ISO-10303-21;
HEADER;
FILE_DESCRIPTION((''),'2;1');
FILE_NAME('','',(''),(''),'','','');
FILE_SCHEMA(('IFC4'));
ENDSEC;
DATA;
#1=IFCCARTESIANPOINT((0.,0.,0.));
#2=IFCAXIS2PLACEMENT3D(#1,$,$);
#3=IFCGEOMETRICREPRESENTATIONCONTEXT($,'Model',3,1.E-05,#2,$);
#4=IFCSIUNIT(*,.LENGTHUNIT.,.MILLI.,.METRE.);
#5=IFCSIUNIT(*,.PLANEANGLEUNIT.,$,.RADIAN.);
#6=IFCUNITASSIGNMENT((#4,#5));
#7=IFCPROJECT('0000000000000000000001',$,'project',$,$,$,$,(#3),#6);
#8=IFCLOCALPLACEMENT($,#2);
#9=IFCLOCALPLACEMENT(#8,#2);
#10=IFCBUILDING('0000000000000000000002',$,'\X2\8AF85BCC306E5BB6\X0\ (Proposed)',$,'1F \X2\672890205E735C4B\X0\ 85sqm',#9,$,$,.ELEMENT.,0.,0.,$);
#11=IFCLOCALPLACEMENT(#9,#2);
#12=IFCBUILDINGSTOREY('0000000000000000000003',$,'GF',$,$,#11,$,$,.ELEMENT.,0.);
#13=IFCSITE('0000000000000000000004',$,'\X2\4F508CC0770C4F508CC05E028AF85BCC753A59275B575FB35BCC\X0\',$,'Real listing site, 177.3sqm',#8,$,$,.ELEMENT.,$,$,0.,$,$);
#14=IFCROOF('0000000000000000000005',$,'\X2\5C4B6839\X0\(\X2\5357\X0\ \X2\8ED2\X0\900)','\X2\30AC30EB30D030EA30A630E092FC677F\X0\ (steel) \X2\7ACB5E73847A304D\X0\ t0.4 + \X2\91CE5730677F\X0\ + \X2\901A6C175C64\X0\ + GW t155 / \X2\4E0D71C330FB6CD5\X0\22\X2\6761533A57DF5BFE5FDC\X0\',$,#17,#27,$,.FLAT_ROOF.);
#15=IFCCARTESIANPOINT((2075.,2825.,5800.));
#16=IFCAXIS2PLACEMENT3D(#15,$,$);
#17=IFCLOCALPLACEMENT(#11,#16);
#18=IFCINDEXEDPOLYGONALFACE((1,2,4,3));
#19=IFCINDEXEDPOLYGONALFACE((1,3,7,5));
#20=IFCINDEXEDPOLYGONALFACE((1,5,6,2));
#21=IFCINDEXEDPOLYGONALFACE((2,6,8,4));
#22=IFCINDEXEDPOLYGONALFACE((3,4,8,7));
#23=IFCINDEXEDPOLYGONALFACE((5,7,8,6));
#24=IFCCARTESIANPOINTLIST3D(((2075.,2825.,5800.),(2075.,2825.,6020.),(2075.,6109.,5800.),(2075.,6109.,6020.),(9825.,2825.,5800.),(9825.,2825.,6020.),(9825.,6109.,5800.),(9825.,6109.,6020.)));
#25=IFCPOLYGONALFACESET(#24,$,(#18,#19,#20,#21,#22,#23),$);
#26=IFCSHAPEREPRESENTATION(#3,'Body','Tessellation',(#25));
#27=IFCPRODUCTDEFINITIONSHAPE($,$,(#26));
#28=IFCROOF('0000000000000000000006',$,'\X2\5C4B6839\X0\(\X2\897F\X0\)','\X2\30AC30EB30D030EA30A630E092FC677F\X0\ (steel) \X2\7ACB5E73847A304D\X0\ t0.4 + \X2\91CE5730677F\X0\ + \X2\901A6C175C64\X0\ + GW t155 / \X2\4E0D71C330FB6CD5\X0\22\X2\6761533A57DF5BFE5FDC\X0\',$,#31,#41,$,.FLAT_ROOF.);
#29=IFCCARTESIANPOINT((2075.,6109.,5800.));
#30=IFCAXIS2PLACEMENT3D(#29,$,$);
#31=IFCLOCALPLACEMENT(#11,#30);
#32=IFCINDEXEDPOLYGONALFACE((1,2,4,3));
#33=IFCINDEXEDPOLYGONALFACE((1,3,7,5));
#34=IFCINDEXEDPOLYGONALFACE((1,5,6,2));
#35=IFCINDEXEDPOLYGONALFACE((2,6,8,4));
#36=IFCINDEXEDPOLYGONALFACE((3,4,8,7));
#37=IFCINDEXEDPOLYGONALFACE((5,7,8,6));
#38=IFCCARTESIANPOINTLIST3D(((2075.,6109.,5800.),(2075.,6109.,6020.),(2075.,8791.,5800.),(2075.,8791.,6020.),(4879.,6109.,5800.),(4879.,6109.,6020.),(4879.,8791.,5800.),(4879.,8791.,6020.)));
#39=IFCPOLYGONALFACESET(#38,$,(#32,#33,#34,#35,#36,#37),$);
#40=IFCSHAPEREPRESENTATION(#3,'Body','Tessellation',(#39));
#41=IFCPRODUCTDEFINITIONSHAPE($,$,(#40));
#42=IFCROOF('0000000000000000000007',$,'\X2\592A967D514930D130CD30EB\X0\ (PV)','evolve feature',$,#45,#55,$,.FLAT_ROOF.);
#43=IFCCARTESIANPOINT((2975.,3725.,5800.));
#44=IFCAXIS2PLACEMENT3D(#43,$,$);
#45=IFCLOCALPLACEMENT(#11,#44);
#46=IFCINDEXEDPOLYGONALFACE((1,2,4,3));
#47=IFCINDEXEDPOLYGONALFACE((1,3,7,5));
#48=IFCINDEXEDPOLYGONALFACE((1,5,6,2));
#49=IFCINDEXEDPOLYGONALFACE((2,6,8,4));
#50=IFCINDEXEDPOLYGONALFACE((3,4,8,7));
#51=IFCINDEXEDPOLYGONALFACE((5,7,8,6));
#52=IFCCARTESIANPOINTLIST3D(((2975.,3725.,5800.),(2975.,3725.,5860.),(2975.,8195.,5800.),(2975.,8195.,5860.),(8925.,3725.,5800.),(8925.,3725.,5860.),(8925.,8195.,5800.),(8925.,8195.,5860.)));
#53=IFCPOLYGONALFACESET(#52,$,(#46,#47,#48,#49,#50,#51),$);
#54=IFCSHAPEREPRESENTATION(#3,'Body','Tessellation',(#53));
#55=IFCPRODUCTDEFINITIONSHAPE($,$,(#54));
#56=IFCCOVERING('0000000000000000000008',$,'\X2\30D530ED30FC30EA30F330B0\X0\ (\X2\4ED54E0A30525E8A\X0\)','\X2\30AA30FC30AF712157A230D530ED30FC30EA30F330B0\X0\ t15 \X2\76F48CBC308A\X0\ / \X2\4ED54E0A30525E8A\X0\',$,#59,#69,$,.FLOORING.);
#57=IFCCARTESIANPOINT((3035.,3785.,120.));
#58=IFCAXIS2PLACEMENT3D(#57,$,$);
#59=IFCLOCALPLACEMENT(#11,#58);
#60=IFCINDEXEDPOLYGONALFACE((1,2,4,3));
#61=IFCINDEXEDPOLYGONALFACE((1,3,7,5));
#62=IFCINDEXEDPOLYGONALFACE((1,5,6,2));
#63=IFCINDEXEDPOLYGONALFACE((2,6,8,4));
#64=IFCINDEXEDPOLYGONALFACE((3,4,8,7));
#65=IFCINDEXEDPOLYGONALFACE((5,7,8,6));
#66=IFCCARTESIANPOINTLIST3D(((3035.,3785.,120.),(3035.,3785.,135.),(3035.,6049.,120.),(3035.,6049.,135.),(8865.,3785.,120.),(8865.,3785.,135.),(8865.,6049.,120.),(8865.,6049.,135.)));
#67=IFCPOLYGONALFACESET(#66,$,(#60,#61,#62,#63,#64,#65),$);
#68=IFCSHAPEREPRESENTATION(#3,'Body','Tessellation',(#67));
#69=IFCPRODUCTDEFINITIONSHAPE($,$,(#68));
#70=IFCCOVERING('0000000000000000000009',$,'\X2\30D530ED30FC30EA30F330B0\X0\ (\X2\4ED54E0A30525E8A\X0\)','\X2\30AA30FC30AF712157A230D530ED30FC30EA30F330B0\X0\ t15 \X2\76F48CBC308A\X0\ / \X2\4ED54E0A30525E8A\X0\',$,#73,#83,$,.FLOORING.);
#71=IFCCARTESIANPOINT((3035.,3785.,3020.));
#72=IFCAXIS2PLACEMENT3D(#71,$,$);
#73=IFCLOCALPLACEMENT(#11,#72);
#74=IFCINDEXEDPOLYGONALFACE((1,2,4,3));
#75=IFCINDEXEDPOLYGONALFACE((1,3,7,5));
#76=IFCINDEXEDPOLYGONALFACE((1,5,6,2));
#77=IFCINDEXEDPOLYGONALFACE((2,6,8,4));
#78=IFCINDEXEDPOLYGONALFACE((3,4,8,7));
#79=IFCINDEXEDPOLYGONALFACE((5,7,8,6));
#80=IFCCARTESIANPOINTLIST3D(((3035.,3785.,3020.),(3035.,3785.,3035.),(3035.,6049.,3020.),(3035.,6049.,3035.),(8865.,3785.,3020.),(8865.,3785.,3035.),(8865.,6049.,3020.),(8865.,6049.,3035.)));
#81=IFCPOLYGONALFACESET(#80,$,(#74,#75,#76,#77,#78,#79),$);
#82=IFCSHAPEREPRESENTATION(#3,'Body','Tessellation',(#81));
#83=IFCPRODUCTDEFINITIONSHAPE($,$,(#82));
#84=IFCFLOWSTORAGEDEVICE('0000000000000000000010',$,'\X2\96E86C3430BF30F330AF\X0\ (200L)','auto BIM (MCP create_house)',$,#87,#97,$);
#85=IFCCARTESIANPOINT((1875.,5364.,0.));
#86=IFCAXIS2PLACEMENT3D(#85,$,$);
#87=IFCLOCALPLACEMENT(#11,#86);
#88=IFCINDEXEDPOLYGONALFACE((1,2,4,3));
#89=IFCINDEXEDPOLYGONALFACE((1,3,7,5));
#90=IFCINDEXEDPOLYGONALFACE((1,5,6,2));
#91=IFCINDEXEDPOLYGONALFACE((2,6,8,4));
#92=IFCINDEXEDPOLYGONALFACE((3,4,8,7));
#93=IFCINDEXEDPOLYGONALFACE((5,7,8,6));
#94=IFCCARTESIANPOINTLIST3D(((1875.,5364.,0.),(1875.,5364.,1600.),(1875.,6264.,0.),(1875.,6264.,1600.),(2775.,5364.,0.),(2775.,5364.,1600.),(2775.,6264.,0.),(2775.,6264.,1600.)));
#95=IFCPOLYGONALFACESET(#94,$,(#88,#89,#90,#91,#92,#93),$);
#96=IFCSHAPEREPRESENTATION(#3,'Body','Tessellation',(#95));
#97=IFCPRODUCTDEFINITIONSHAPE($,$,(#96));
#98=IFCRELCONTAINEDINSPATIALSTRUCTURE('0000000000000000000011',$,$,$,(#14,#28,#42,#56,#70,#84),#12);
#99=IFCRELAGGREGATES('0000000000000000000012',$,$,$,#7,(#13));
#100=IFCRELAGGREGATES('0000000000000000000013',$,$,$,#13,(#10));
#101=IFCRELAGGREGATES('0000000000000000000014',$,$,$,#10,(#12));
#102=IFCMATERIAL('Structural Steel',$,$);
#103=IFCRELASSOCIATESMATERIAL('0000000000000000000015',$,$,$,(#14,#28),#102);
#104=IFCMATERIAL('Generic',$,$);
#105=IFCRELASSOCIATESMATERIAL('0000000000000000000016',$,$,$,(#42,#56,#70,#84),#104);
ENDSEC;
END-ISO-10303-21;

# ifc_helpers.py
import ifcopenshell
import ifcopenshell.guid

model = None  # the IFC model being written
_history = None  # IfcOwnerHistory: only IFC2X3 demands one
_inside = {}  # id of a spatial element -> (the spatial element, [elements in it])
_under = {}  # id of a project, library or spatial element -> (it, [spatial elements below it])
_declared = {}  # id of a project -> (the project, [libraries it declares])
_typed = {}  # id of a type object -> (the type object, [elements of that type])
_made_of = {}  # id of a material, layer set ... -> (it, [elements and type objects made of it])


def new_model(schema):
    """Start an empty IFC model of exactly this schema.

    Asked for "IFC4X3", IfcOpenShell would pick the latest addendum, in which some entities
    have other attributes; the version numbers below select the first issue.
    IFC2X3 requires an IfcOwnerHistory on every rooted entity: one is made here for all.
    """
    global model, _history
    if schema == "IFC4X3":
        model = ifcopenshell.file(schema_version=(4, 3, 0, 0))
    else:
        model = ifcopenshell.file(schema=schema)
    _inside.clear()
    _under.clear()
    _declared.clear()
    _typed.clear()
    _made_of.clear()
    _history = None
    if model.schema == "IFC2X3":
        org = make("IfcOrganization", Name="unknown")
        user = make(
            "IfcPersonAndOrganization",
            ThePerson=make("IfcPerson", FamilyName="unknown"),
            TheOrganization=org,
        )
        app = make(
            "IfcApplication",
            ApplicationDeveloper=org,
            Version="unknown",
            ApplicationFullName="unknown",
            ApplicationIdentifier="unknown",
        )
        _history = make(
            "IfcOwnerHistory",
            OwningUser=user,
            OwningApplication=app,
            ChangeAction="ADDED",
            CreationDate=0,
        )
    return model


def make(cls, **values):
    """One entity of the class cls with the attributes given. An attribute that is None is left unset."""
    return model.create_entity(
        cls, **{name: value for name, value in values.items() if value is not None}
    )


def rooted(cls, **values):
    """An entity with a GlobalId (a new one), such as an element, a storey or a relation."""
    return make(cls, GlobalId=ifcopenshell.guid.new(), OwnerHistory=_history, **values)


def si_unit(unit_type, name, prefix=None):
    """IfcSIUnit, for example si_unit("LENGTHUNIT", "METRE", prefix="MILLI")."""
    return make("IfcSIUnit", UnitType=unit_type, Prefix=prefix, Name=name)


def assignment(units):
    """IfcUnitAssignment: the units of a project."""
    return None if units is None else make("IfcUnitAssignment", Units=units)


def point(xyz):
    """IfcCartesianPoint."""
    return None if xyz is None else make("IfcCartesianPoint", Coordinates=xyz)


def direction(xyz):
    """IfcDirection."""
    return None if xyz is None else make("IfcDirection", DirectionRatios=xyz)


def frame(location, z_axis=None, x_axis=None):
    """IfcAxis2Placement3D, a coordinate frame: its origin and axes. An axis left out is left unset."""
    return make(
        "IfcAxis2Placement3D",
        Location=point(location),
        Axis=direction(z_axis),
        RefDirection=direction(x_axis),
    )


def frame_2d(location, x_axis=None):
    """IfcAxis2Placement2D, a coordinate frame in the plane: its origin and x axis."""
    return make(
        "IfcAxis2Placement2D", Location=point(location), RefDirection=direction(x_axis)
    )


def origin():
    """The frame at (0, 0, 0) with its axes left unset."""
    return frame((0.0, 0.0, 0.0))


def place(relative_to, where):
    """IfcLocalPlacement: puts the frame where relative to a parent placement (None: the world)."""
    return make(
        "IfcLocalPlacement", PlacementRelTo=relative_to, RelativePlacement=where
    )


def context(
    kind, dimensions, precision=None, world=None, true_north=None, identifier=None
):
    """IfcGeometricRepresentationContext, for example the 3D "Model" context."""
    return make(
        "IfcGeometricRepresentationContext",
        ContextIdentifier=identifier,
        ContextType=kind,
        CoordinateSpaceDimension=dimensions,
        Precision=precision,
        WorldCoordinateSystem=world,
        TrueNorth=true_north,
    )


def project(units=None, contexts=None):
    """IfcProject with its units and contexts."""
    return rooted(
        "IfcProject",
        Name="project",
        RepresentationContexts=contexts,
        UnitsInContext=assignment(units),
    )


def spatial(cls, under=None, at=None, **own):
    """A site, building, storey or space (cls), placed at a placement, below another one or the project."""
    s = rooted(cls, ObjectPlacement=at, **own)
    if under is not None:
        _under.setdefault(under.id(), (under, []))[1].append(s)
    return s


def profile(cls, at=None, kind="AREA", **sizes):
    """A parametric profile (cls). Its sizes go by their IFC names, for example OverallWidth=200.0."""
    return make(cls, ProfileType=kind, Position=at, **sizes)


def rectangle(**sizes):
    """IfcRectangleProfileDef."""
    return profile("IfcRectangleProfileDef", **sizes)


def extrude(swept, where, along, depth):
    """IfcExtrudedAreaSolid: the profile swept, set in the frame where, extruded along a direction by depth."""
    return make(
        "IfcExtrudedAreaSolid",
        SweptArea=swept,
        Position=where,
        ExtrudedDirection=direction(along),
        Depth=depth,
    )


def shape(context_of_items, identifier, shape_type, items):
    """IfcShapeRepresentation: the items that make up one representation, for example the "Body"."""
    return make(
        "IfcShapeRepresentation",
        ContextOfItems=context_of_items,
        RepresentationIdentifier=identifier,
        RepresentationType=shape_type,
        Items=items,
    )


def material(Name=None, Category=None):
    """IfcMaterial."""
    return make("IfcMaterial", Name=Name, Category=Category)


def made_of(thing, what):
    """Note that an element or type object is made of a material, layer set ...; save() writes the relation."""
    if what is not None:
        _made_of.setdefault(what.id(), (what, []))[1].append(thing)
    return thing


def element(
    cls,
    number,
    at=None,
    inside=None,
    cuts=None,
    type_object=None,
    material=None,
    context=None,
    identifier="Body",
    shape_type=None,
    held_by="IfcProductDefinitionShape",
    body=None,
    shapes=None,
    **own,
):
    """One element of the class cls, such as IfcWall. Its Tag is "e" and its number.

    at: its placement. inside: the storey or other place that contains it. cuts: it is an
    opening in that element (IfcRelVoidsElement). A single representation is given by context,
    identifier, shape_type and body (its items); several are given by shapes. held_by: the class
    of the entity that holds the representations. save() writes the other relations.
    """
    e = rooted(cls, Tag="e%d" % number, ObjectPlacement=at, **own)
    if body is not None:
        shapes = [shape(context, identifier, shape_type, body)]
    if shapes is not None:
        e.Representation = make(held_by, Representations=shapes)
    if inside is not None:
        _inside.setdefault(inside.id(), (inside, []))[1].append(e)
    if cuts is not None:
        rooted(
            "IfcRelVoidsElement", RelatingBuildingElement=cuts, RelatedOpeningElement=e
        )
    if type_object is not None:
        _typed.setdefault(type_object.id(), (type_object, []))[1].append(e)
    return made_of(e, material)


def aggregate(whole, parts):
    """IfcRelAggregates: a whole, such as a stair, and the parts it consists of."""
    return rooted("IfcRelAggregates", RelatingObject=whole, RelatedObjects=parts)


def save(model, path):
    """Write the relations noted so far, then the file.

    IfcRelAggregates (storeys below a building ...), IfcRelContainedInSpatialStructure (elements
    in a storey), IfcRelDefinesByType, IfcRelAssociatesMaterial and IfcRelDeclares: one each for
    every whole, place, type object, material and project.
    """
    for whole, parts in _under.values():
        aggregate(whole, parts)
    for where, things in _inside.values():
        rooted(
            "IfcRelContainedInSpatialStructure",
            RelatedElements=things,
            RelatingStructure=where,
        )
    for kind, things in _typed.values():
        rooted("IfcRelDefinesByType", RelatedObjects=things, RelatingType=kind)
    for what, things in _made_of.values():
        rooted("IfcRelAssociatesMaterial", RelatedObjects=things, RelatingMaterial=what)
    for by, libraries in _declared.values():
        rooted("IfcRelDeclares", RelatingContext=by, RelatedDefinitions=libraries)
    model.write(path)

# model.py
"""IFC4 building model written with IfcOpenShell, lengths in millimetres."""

from ifc_helpers import new_model, si_unit, frame, frame_2d, origin, place, context, project, spatial, rectangle, extrude, material, element, save


model = new_model("IFC4")

# Units and contexts
model_context = context("Model", 3, precision=1e-05, world=origin())
ifc_project = project(units=[si_unit("LENGTHUNIT", "METRE", prefix="MILLI"), si_unit("PLANEANGLEUNIT", "RADIAN")], contexts=[model_context])

# Site, building, storey
site_placement = place(None, origin())
site = spatial("IfcSite", under=ifc_project, at=site_placement, Name="佐賀県佐賀市諸富町大字徳富", ObjectType="Real listing site, 177.3sqm", CompositionType="ELEMENT", RefElevation=0.0)
building_placement = place(site_placement, origin())
building = spatial("IfcBuilding", under=site, at=building_placement, Name="諸富の家 (Proposed)", ObjectType="1F 木造平屋 85sqm", CompositionType="ELEMENT", ElevationOfRefHeight=0.0, ElevationOfTerrain=0.0)
storey_placement = place(building_placement, origin())
storey = spatial("IfcBuildingStorey", under=building, at=storey_placement, Name="GF", CompositionType="ELEMENT", Elevation=0.0)

# Shared definitions
ifc_material_1 = material(Name="Generic")

# Roofs
ifc_material_2 = material(Name="Structural Steel")
roof_1_placement = place(storey_placement, frame((2075.0, 2825.0, 5800.0)))
element("IfcRoof", 1, at=roof_1_placement, inside=storey, material=ifc_material_2, Name="屋根(南 軒900)", Description="ガルバリウム鋼板 (steel) 立平葺き t0.4 + 野地板 + 通気層 + GW t155 / 不燃・法22条区域対応", PredefinedType="FLAT_ROOF", context=model_context, shape_type="SweptSolid", body=[
    extrude(rectangle(XDim=7750.0, YDim=3284.0, at=frame_2d((3875.0, 1642.0))), frame((2075.0, 2825.0, 5800.0)), (0.0, 0.0, 1.0), 220.0),
])
roof_2_placement = place(storey_placement, frame((2075.0, 6109.0, 5800.0)))
element("IfcRoof", 2, at=roof_2_placement, inside=storey, material=ifc_material_2, Name="屋根(西)", Description="ガルバリウム鋼板 (steel) 立平葺き t0.4 + 野地板 + 通気層 + GW t155 / 不燃・法22条区域対応", PredefinedType="FLAT_ROOF", context=model_context, shape_type="SweptSolid", body=[
    extrude(rectangle(XDim=2804.0, YDim=2682.0, at=frame_2d((1402.0, 1341.0))), frame((2075.0, 6109.0, 5800.0)), (0.0, 0.0, 1.0), 220.0),
])
roof_3_placement = place(storey_placement, frame((2975.0, 3725.0, 5800.0)))
element("IfcRoof", 3, at=roof_3_placement, inside=storey, material=ifc_material_1, Name="太陽光パネル (PV)", Description="evolve feature", PredefinedType="FLAT_ROOF", context=model_context, shape_type="SweptSolid", body=[
    extrude(rectangle(XDim=5950.0, YDim=4470.0, at=frame_2d((2975.0, 2235.0))), frame((2975.0, 3725.0, 5800.0)), (0.0, 0.0, 1.0), 60.0),
])

# Coverings
covering_1_placement = place(storey_placement, frame((3035.0, 3785.0, 120.0)))
element("IfcCovering", 4, at=covering_1_placement, inside=storey, material=ifc_material_1, Name="フローリング (仕上げ床)", Description="オーク無垢フローリング t15 直貼り / 仕上げ床", PredefinedType="FLOORING", context=model_context, shape_type="SweptSolid", body=[
    extrude(rectangle(XDim=5830.0, YDim=2264.0, at=frame_2d((2915.0, 1132.0))), frame((3035.0, 3785.0, 120.0)), (0.0, 0.0, 1.0), 15.0),
])
covering_2_placement = place(storey_placement, frame((3035.0, 3785.0, 3020.0)))
element("IfcCovering", 5, at=covering_2_placement, inside=storey, material=ifc_material_1, Name="フローリング (仕上げ床)", Description="オーク無垢フローリング t15 直貼り / 仕上げ床", PredefinedType="FLOORING", context=model_context, shape_type="SweptSolid", body=[
    extrude(rectangle(XDim=5830.0, YDim=2264.0, at=frame_2d((2915.0, 1132.0))), frame((3035.0, 3785.0, 3020.0)), (0.0, 0.0, 1.0), 15.0),
])

# Flow storage device
flow_storage_device_placement = place(storey_placement, frame((1875.0, 5364.0, 0.0)))
element("IfcFlowStorageDevice", 6, at=flow_storage_device_placement, inside=storey, material=ifc_material_1, Name="雨水タンク (200L)", Description="auto BIM (MCP create_house)", context=model_context, shape_type="SweptSolid", body=[
    extrude(rectangle(XDim=900.0, YDim=900.0, at=frame_2d((450.0, 450.0))), frame((1875.0, 5364.0, 0.0)), (0.0, 0.0, 1.0), 1600.0),
])

save(model, "model.ifc")
